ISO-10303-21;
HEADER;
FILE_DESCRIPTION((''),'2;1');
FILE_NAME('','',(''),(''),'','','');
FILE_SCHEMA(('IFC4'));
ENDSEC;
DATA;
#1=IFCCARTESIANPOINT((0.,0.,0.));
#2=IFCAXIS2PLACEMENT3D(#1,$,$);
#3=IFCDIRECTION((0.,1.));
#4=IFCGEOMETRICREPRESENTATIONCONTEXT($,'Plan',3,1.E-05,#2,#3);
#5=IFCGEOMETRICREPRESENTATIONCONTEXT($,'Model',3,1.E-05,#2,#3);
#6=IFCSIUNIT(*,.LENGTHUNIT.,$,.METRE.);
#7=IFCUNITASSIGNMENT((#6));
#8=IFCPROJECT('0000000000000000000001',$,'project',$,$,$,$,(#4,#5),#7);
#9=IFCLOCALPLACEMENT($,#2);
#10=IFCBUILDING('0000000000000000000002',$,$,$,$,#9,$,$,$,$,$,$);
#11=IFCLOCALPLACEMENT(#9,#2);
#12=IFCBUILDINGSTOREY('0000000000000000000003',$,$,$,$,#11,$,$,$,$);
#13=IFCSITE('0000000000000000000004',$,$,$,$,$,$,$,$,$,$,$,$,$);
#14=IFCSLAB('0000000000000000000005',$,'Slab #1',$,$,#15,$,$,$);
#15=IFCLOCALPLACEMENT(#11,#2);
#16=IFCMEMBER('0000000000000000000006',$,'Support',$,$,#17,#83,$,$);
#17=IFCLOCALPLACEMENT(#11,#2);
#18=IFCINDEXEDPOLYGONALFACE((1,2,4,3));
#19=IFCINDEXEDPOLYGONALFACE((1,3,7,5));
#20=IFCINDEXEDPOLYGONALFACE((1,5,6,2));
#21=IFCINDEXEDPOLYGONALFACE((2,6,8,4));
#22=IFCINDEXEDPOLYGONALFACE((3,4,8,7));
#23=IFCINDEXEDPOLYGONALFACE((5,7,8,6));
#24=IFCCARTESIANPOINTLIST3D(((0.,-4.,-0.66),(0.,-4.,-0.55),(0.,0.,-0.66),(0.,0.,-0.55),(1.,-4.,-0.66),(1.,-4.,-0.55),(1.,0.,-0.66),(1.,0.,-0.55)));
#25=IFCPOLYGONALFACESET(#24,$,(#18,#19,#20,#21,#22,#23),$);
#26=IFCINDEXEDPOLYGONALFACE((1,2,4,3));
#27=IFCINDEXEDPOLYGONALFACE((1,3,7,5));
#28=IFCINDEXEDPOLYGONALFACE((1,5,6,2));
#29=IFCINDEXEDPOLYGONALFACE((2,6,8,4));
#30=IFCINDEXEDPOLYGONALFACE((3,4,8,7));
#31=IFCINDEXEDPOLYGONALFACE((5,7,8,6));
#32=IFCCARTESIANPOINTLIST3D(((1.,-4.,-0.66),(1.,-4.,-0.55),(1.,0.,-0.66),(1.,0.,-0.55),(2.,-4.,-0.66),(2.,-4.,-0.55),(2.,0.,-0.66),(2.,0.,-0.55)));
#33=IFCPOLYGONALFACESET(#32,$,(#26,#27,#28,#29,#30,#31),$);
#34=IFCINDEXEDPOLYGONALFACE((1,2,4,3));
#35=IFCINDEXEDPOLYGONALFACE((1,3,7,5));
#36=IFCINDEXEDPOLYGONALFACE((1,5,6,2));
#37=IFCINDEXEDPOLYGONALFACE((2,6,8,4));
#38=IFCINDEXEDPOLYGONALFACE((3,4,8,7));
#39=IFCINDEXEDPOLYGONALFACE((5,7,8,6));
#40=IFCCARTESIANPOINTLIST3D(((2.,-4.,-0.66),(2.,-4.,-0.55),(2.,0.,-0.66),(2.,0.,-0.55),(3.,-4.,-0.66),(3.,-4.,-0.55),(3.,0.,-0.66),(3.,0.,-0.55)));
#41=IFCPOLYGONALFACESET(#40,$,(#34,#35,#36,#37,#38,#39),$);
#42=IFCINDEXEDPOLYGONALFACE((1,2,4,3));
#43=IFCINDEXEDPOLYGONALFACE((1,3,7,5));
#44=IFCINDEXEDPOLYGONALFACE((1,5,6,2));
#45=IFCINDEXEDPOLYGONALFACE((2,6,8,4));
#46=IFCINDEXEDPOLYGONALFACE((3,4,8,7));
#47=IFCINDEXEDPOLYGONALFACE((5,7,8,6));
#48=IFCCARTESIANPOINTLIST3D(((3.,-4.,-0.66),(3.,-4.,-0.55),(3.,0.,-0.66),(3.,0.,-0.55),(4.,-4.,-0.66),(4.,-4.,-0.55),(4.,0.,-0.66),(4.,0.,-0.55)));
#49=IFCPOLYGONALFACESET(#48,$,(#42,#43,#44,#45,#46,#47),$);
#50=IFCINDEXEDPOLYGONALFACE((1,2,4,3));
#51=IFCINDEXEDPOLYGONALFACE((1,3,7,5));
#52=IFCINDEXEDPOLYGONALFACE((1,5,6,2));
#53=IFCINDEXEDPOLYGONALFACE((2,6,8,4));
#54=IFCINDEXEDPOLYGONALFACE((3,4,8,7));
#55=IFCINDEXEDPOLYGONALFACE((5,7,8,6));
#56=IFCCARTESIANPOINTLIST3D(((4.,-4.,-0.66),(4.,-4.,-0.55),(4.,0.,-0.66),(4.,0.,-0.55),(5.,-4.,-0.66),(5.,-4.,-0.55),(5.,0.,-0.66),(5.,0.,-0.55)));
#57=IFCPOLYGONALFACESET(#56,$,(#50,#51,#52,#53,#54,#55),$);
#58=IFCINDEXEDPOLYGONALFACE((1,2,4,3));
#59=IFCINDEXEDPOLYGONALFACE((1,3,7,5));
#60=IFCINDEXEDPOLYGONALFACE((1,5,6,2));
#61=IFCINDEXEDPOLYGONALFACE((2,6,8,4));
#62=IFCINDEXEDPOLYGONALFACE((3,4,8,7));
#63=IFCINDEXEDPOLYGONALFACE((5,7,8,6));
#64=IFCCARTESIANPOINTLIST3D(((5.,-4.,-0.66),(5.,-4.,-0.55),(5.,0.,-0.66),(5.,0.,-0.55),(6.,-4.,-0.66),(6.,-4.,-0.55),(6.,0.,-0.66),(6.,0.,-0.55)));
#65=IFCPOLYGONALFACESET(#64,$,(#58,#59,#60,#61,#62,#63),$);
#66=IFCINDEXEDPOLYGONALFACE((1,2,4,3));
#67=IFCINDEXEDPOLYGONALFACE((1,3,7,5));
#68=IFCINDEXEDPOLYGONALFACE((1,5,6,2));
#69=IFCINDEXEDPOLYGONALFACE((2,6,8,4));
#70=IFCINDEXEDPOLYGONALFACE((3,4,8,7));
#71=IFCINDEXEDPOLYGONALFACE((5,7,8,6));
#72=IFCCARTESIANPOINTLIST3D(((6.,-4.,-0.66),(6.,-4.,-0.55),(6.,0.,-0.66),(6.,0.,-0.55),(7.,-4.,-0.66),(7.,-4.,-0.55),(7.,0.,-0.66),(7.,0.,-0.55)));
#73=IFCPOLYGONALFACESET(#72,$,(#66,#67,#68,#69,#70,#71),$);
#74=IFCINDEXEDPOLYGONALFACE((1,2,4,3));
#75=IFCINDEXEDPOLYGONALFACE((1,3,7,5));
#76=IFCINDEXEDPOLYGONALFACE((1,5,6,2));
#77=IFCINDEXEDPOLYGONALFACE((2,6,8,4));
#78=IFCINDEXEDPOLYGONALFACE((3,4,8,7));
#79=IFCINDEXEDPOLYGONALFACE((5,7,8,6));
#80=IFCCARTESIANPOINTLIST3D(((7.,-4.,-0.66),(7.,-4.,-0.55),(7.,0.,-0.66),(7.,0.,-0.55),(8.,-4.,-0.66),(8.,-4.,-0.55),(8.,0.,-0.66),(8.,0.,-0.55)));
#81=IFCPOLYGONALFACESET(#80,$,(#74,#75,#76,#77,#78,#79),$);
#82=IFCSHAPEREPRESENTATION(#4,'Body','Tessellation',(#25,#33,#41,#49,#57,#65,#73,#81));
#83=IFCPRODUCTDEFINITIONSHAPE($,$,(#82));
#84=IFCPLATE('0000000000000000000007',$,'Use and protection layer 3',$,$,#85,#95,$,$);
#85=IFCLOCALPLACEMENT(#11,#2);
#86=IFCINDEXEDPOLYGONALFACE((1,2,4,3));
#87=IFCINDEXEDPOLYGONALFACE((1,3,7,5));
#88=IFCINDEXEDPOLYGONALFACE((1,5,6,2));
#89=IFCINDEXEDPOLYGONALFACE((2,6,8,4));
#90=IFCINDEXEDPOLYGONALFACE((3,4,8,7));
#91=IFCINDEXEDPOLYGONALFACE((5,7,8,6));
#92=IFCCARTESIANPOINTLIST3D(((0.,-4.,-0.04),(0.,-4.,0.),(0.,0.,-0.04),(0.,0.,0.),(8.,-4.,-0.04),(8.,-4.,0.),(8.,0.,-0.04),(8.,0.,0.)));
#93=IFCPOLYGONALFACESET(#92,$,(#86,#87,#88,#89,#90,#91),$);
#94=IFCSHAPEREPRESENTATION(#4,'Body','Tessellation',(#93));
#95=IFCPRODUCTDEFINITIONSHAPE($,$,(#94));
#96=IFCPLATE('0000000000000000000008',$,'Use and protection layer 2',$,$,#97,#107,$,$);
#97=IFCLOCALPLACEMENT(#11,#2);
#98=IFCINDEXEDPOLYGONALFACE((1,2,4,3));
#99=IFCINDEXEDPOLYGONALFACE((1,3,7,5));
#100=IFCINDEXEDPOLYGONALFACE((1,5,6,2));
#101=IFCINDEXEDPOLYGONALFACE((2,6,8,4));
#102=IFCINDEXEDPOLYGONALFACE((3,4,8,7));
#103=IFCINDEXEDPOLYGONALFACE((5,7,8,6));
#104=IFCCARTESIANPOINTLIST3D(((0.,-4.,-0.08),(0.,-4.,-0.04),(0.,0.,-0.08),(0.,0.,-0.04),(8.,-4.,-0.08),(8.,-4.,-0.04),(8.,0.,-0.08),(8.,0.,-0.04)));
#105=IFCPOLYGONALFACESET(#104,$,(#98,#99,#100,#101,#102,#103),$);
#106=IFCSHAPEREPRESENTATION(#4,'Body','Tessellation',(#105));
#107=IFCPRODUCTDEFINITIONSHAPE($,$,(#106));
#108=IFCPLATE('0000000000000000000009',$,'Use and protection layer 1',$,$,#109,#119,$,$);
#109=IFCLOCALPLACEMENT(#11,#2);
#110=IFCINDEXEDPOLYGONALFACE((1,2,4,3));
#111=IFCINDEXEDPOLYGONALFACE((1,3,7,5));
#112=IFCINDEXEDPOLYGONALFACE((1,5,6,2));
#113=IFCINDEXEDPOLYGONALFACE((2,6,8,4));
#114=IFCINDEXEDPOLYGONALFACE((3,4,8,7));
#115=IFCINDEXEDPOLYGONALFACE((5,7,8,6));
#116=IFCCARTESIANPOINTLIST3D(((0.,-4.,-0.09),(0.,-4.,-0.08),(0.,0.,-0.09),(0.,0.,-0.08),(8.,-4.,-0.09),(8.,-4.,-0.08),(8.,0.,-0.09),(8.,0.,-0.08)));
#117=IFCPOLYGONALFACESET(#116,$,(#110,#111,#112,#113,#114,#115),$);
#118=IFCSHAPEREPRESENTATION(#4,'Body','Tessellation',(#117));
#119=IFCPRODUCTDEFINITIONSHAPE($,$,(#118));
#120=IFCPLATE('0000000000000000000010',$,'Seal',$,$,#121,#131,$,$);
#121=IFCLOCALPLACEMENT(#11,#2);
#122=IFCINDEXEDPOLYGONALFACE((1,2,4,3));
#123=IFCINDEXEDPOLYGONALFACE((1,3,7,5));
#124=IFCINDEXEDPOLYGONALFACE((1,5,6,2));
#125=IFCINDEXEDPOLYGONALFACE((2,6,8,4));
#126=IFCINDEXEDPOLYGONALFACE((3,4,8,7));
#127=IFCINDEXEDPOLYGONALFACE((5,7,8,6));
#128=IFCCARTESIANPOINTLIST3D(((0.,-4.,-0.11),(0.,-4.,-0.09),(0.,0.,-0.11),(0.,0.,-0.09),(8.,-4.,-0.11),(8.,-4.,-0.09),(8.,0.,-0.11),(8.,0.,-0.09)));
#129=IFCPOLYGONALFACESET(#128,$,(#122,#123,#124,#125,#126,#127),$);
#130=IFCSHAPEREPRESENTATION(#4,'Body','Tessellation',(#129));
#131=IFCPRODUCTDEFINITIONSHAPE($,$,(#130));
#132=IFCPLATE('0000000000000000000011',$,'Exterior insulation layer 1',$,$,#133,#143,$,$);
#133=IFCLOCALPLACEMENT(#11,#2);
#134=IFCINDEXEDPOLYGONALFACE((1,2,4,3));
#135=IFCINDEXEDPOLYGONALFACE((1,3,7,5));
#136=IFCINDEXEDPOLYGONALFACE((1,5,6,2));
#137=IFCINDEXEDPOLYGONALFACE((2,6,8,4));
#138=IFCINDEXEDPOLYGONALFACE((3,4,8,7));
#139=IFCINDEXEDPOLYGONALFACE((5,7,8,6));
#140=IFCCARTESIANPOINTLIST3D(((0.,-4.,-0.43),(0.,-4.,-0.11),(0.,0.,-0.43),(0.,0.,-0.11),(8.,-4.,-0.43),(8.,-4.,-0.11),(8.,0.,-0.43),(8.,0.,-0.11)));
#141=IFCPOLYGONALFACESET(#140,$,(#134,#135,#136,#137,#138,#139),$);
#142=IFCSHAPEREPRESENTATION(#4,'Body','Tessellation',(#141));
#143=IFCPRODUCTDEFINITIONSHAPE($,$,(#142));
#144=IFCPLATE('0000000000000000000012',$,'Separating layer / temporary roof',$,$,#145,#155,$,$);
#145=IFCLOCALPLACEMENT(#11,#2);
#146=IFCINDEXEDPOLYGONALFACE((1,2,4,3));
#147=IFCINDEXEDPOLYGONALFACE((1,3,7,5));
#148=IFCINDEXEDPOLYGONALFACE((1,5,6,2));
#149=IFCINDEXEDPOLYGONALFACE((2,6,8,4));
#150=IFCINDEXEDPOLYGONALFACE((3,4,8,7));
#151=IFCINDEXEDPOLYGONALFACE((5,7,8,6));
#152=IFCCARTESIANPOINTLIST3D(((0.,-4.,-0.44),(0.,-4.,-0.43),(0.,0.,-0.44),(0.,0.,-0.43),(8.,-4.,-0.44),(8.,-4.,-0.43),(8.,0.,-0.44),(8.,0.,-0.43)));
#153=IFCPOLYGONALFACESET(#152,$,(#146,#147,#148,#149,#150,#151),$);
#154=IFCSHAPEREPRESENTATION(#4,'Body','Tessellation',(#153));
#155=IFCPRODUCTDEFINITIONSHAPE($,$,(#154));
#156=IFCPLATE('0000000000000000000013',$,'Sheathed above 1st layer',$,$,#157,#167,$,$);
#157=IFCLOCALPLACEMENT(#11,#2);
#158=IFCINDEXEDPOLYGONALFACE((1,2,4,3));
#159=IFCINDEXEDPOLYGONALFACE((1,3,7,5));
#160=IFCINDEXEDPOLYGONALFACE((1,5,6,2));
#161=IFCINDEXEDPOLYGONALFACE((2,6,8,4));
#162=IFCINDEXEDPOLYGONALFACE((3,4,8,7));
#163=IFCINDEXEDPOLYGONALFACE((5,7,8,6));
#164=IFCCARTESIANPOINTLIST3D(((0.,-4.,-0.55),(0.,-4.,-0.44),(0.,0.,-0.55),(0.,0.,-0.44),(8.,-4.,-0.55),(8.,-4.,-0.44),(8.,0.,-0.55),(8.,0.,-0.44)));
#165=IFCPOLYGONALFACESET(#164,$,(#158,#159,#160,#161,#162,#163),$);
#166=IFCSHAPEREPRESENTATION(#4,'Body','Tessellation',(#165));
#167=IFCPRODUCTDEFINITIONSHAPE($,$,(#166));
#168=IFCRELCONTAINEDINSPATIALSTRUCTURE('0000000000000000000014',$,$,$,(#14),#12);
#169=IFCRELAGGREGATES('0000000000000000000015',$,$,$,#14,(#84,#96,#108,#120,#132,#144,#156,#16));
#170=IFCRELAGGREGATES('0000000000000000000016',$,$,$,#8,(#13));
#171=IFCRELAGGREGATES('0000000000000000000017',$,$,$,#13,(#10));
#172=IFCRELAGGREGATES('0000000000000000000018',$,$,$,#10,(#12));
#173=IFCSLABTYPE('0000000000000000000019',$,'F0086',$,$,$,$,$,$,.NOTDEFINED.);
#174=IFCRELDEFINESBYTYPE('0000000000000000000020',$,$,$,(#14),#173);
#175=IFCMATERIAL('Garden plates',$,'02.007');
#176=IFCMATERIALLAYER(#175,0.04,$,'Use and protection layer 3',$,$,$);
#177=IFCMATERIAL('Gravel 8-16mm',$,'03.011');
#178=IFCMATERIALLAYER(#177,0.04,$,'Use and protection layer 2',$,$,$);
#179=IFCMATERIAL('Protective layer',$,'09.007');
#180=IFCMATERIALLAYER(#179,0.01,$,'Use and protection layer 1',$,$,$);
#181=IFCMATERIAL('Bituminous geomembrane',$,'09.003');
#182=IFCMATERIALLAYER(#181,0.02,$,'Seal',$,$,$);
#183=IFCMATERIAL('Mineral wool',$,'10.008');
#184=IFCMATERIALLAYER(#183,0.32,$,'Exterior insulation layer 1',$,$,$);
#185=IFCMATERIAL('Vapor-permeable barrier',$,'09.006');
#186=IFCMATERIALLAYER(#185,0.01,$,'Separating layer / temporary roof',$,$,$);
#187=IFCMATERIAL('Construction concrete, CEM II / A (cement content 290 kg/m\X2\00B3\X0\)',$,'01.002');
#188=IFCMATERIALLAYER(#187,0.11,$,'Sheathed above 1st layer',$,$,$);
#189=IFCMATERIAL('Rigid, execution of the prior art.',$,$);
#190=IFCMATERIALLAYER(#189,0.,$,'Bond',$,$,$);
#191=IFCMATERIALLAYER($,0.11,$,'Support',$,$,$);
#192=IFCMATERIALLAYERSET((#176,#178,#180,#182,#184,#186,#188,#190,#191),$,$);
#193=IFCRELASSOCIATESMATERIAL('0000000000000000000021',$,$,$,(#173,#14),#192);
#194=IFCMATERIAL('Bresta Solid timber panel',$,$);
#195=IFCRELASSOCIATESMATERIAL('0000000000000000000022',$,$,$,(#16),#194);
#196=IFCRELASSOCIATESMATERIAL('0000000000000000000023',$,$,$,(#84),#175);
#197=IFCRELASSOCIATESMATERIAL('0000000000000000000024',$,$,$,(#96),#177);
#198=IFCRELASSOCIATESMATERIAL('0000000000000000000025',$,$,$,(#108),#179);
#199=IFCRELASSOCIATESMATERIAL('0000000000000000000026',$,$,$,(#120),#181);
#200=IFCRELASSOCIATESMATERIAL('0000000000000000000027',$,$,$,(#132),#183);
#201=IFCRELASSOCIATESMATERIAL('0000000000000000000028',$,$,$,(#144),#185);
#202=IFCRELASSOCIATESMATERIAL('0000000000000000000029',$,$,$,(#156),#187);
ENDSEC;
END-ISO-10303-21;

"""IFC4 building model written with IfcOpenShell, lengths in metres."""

from ifc_helpers import new_model, si_unit, direction, frame, frame_2d, origin, origin_with_axes, place, context, project, spatial, rectangle, extrude, material, layer, layer_set, type_object, element, aggregate, save


model = new_model("IFC4")

# Units and contexts
plan_context = context("Plan", 3, precision=1e-05, world=origin(), true_north=direction((0.0, 1.0)))
model_context = context("Model", 3, precision=1e-05, world=origin(), true_north=direction((0.0, 1.0)))
ifc_project = project(units=[si_unit("LENGTHUNIT", "METRE")], contexts=[plan_context, model_context])

# Site, building, storey
site = spatial("IfcSite", under=ifc_project)
building_placement = place(None, origin())
building = spatial("IfcBuilding", under=site, at=building_placement)
storey_placement = place(building_placement, origin())
storey = spatial("IfcBuildingStorey", under=building, at=storey_placement)

# Slab, member, plates
ifc_material_1 = material(Name="Garden plates", Category="02.007")
ifc_layer_1 = layer(ifc_material_1, 0.04, Name="Use and protection layer 3")
ifc_material_2 = material(Name="Gravel 8-16mm", Category="03.011")
ifc_layer_2 = layer(ifc_material_2, 0.04, Name="Use and protection layer 2")
ifc_material_3 = material(Name="Protective layer", Category="09.007")
ifc_layer_3 = layer(ifc_material_3, 0.01, Name="Use and protection layer 1")
ifc_material_4 = material(Name="Bituminous geomembrane", Category="09.003")
ifc_layer_4 = layer(ifc_material_4, 0.02, Name="Seal")
ifc_material_5 = material(Name="Mineral wool", Category="10.008")
ifc_layer_5 = layer(ifc_material_5, 0.32, Name="Exterior insulation layer 1")
ifc_material_6 = material(Name="Vapor-permeable barrier", Category="09.006")
ifc_layer_6 = layer(ifc_material_6, 0.01, Name="Separating layer / temporary roof")
ifc_material_7 = material(Name="Construction concrete, CEM II / A (cement content 290 kg/m³)", Category="01.002")
ifc_layer_7 = layer(ifc_material_7, 0.11, Name="Sheathed above 1st layer")
ifc_material_8 = material(Name="Rigid, execution of the prior art.")
ifc_layer_8 = layer(ifc_material_8, 0.0, Name="Bond")
ifc_layer_9 = layer(None, 0.11, Name="Support")
ifc_layer_set = layer_set([ifc_layer_1, ifc_layer_2, ifc_layer_3, ifc_layer_4, ifc_layer_5, ifc_layer_6, ifc_layer_7, ifc_layer_8, ifc_layer_9])
slab_type = type_object("IfcSlabType", Name="F0086", PredefinedType="NOTDEFINED", material=ifc_layer_set)
slab_placement = place(None, frame((0.0, 0.0, 0.0), z_axis=(0.0, 0.0, -1.0), x_axis=(1.0, 0.0, 0.0)))
slab = element("IfcSlab", 1, at=slab_placement, inside=storey, type_object=slab_type, material=ifc_layer_set, Name="Slab #1")
ifc_material_9 = material(Name="Bresta Solid timber panel")
member_placement = place(slab_placement, origin())
member = element("IfcMember", 2, at=member_placement, material=ifc_material_9, Name="Support", context=plan_context, shape_type="SweptSolid", body=[
    extrude(rectangle(XDim=1.0, YDim=0.11, at=frame_2d((0.5, 0.055), x_axis=(1.0, 0.0))), frame((0.0, 4.0, 0.55), z_axis=(0.0, -1.0, 0.0), x_axis=(1.0, 0.0, 0.0)), (0.0, 0.0, 1.0), 4.0),
    extrude(rectangle(XDim=1.0, YDim=0.11, at=frame_2d((0.5, 0.055), x_axis=(1.0, 0.0))), frame((1.0, 4.0, 0.55), z_axis=(0.0, -1.0, 0.0), x_axis=(1.0, 0.0, 0.0)), (0.0, 0.0, 1.0), 4.0),
    extrude(rectangle(XDim=1.0, YDim=0.11, at=frame_2d((0.5, 0.055), x_axis=(1.0, 0.0))), frame((2.0, 4.0, 0.55), z_axis=(0.0, -1.0, 0.0), x_axis=(1.0, 0.0, 0.0)), (0.0, 0.0, 1.0), 4.0),
    extrude(rectangle(XDim=1.0, YDim=0.11, at=frame_2d((0.5, 0.055), x_axis=(1.0, 0.0))), frame((3.0, 4.0, 0.55), z_axis=(0.0, -1.0, 0.0), x_axis=(1.0, 0.0, 0.0)), (0.0, 0.0, 1.0), 4.0),
    extrude(rectangle(XDim=1.0, YDim=0.11, at=frame_2d((0.5, 0.055), x_axis=(1.0, 0.0))), frame((4.0, 4.0, 0.55), z_axis=(0.0, -1.0, 0.0), x_axis=(1.0, 0.0, 0.0)), (0.0, 0.0, 1.0), 4.0),
    extrude(rectangle(XDim=1.0, YDim=0.11, at=frame_2d((0.5, 0.055), x_axis=(1.0, 0.0))), frame((5.0, 4.0, 0.55), z_axis=(0.0, -1.0, 0.0), x_axis=(1.0, 0.0, 0.0)), (0.0, 0.0, 1.0), 4.0),
    extrude(rectangle(XDim=1.0, YDim=0.11, at=frame_2d((0.5, 0.055), x_axis=(1.0, 0.0))), frame((6.0, 4.0, 0.55), z_axis=(0.0, -1.0, 0.0), x_axis=(1.0, 0.0, 0.0)), (0.0, 0.0, 1.0), 4.0),
    extrude(rectangle(XDim=1.0, YDim=0.11, at=frame_2d((0.5, 0.055), x_axis=(1.0, 0.0))), frame((7.0, 4.0, 0.55), z_axis=(0.0, -1.0, 0.0), x_axis=(1.0, 0.0, 0.0)), (0.0, 0.0, 1.0), 4.0),
])
plate_1_placement = place(slab_placement, origin())
plate_1 = element("IfcPlate", 3, at=plate_1_placement, material=ifc_material_1, Name="Use and protection layer 3", context=plan_context, shape_type="SweptSolid", body=[
    extrude(rectangle(XDim=8.0, YDim=4.0, at=frame_2d((4.0, 2.0), x_axis=(1.0, 0.0))), origin_with_axes(), (0.0, 0.0, 1.0), 0.04),
])
plate_2_placement = place(slab_placement, origin())
plate_2 = element("IfcPlate", 4, at=plate_2_placement, material=ifc_material_2, Name="Use and protection layer 2", context=plan_context, shape_type="SweptSolid", body=[
    extrude(rectangle(XDim=8.0, YDim=4.0, at=frame_2d((4.0, 2.0), x_axis=(1.0, 0.0))), frame((0.0, 0.0, 0.04), z_axis=(0.0, 0.0, 1.0), x_axis=(1.0, 0.0, 0.0)), (0.0, 0.0, 1.0), 0.04),
])
plate_3_placement = place(slab_placement, origin())
plate_3 = element("IfcPlate", 5, at=plate_3_placement, material=ifc_material_3, Name="Use and protection layer 1", context=plan_context, shape_type="SweptSolid", body=[
    extrude(rectangle(XDim=8.0, YDim=4.0, at=frame_2d((4.0, 2.0), x_axis=(1.0, 0.0))), frame((0.0, 0.0, 0.08), z_axis=(0.0, 0.0, 1.0), x_axis=(1.0, 0.0, 0.0)), (0.0, 0.0, 1.0), 0.01),
])
plate_4_placement = place(slab_placement, origin())
plate_4 = element("IfcPlate", 6, at=plate_4_placement, material=ifc_material_4, Name="Seal", context=plan_context, shape_type="SweptSolid", body=[
    extrude(rectangle(XDim=8.0, YDim=4.0, at=frame_2d((4.0, 2.0), x_axis=(1.0, 0.0))), frame((0.0, 0.0, 0.09), z_axis=(0.0, 0.0, 1.0), x_axis=(1.0, 0.0, 0.0)), (0.0, 0.0, 1.0), 0.02),
])
plate_5_placement = place(slab_placement, origin())
plate_5 = element("IfcPlate", 7, at=plate_5_placement, material=ifc_material_5, Name="Exterior insulation layer 1", context=plan_context, shape_type="SweptSolid", body=[
    extrude(rectangle(XDim=8.0, YDim=4.0, at=frame_2d((4.0, 2.0), x_axis=(1.0, 0.0))), frame((0.0, 0.0, 0.11), z_axis=(0.0, 0.0, 1.0), x_axis=(1.0, 0.0, 0.0)), (0.0, 0.0, 1.0), 0.32),
])
plate_6_placement = place(slab_placement, origin())
plate_6 = element("IfcPlate", 8, at=plate_6_placement, material=ifc_material_6, Name="Separating layer / temporary roof", context=plan_context, shape_type="SweptSolid", body=[
    extrude(rectangle(XDim=8.0, YDim=4.0, at=frame_2d((4.0, 2.0), x_axis=(1.0, 0.0))), frame((0.0, 0.0, 0.43), z_axis=(0.0, 0.0, 1.0), x_axis=(1.0, 0.0, 0.0)), (0.0, 0.0, 1.0), 0.01),
])
plate_7_placement = place(slab_placement, origin())
plate_7 = element("IfcPlate", 9, at=plate_7_placement, material=ifc_material_7, Name="Sheathed above 1st layer", context=plan_context, shape_type="SweptSolid", body=[
    extrude(rectangle(XDim=8.0, YDim=4.0, at=frame_2d((4.0, 2.0), x_axis=(1.0, 0.0))), frame((0.0, 0.0, 0.44), z_axis=(0.0, 0.0, 1.0), x_axis=(1.0, 0.0, 0.0)), (0.0, 0.0, 1.0), 0.11),
])
aggregate(slab, [plate_1, plate_2, plate_3, plate_4, plate_5, plate_6, plate_7, member])

save(model, "model.ifc")
